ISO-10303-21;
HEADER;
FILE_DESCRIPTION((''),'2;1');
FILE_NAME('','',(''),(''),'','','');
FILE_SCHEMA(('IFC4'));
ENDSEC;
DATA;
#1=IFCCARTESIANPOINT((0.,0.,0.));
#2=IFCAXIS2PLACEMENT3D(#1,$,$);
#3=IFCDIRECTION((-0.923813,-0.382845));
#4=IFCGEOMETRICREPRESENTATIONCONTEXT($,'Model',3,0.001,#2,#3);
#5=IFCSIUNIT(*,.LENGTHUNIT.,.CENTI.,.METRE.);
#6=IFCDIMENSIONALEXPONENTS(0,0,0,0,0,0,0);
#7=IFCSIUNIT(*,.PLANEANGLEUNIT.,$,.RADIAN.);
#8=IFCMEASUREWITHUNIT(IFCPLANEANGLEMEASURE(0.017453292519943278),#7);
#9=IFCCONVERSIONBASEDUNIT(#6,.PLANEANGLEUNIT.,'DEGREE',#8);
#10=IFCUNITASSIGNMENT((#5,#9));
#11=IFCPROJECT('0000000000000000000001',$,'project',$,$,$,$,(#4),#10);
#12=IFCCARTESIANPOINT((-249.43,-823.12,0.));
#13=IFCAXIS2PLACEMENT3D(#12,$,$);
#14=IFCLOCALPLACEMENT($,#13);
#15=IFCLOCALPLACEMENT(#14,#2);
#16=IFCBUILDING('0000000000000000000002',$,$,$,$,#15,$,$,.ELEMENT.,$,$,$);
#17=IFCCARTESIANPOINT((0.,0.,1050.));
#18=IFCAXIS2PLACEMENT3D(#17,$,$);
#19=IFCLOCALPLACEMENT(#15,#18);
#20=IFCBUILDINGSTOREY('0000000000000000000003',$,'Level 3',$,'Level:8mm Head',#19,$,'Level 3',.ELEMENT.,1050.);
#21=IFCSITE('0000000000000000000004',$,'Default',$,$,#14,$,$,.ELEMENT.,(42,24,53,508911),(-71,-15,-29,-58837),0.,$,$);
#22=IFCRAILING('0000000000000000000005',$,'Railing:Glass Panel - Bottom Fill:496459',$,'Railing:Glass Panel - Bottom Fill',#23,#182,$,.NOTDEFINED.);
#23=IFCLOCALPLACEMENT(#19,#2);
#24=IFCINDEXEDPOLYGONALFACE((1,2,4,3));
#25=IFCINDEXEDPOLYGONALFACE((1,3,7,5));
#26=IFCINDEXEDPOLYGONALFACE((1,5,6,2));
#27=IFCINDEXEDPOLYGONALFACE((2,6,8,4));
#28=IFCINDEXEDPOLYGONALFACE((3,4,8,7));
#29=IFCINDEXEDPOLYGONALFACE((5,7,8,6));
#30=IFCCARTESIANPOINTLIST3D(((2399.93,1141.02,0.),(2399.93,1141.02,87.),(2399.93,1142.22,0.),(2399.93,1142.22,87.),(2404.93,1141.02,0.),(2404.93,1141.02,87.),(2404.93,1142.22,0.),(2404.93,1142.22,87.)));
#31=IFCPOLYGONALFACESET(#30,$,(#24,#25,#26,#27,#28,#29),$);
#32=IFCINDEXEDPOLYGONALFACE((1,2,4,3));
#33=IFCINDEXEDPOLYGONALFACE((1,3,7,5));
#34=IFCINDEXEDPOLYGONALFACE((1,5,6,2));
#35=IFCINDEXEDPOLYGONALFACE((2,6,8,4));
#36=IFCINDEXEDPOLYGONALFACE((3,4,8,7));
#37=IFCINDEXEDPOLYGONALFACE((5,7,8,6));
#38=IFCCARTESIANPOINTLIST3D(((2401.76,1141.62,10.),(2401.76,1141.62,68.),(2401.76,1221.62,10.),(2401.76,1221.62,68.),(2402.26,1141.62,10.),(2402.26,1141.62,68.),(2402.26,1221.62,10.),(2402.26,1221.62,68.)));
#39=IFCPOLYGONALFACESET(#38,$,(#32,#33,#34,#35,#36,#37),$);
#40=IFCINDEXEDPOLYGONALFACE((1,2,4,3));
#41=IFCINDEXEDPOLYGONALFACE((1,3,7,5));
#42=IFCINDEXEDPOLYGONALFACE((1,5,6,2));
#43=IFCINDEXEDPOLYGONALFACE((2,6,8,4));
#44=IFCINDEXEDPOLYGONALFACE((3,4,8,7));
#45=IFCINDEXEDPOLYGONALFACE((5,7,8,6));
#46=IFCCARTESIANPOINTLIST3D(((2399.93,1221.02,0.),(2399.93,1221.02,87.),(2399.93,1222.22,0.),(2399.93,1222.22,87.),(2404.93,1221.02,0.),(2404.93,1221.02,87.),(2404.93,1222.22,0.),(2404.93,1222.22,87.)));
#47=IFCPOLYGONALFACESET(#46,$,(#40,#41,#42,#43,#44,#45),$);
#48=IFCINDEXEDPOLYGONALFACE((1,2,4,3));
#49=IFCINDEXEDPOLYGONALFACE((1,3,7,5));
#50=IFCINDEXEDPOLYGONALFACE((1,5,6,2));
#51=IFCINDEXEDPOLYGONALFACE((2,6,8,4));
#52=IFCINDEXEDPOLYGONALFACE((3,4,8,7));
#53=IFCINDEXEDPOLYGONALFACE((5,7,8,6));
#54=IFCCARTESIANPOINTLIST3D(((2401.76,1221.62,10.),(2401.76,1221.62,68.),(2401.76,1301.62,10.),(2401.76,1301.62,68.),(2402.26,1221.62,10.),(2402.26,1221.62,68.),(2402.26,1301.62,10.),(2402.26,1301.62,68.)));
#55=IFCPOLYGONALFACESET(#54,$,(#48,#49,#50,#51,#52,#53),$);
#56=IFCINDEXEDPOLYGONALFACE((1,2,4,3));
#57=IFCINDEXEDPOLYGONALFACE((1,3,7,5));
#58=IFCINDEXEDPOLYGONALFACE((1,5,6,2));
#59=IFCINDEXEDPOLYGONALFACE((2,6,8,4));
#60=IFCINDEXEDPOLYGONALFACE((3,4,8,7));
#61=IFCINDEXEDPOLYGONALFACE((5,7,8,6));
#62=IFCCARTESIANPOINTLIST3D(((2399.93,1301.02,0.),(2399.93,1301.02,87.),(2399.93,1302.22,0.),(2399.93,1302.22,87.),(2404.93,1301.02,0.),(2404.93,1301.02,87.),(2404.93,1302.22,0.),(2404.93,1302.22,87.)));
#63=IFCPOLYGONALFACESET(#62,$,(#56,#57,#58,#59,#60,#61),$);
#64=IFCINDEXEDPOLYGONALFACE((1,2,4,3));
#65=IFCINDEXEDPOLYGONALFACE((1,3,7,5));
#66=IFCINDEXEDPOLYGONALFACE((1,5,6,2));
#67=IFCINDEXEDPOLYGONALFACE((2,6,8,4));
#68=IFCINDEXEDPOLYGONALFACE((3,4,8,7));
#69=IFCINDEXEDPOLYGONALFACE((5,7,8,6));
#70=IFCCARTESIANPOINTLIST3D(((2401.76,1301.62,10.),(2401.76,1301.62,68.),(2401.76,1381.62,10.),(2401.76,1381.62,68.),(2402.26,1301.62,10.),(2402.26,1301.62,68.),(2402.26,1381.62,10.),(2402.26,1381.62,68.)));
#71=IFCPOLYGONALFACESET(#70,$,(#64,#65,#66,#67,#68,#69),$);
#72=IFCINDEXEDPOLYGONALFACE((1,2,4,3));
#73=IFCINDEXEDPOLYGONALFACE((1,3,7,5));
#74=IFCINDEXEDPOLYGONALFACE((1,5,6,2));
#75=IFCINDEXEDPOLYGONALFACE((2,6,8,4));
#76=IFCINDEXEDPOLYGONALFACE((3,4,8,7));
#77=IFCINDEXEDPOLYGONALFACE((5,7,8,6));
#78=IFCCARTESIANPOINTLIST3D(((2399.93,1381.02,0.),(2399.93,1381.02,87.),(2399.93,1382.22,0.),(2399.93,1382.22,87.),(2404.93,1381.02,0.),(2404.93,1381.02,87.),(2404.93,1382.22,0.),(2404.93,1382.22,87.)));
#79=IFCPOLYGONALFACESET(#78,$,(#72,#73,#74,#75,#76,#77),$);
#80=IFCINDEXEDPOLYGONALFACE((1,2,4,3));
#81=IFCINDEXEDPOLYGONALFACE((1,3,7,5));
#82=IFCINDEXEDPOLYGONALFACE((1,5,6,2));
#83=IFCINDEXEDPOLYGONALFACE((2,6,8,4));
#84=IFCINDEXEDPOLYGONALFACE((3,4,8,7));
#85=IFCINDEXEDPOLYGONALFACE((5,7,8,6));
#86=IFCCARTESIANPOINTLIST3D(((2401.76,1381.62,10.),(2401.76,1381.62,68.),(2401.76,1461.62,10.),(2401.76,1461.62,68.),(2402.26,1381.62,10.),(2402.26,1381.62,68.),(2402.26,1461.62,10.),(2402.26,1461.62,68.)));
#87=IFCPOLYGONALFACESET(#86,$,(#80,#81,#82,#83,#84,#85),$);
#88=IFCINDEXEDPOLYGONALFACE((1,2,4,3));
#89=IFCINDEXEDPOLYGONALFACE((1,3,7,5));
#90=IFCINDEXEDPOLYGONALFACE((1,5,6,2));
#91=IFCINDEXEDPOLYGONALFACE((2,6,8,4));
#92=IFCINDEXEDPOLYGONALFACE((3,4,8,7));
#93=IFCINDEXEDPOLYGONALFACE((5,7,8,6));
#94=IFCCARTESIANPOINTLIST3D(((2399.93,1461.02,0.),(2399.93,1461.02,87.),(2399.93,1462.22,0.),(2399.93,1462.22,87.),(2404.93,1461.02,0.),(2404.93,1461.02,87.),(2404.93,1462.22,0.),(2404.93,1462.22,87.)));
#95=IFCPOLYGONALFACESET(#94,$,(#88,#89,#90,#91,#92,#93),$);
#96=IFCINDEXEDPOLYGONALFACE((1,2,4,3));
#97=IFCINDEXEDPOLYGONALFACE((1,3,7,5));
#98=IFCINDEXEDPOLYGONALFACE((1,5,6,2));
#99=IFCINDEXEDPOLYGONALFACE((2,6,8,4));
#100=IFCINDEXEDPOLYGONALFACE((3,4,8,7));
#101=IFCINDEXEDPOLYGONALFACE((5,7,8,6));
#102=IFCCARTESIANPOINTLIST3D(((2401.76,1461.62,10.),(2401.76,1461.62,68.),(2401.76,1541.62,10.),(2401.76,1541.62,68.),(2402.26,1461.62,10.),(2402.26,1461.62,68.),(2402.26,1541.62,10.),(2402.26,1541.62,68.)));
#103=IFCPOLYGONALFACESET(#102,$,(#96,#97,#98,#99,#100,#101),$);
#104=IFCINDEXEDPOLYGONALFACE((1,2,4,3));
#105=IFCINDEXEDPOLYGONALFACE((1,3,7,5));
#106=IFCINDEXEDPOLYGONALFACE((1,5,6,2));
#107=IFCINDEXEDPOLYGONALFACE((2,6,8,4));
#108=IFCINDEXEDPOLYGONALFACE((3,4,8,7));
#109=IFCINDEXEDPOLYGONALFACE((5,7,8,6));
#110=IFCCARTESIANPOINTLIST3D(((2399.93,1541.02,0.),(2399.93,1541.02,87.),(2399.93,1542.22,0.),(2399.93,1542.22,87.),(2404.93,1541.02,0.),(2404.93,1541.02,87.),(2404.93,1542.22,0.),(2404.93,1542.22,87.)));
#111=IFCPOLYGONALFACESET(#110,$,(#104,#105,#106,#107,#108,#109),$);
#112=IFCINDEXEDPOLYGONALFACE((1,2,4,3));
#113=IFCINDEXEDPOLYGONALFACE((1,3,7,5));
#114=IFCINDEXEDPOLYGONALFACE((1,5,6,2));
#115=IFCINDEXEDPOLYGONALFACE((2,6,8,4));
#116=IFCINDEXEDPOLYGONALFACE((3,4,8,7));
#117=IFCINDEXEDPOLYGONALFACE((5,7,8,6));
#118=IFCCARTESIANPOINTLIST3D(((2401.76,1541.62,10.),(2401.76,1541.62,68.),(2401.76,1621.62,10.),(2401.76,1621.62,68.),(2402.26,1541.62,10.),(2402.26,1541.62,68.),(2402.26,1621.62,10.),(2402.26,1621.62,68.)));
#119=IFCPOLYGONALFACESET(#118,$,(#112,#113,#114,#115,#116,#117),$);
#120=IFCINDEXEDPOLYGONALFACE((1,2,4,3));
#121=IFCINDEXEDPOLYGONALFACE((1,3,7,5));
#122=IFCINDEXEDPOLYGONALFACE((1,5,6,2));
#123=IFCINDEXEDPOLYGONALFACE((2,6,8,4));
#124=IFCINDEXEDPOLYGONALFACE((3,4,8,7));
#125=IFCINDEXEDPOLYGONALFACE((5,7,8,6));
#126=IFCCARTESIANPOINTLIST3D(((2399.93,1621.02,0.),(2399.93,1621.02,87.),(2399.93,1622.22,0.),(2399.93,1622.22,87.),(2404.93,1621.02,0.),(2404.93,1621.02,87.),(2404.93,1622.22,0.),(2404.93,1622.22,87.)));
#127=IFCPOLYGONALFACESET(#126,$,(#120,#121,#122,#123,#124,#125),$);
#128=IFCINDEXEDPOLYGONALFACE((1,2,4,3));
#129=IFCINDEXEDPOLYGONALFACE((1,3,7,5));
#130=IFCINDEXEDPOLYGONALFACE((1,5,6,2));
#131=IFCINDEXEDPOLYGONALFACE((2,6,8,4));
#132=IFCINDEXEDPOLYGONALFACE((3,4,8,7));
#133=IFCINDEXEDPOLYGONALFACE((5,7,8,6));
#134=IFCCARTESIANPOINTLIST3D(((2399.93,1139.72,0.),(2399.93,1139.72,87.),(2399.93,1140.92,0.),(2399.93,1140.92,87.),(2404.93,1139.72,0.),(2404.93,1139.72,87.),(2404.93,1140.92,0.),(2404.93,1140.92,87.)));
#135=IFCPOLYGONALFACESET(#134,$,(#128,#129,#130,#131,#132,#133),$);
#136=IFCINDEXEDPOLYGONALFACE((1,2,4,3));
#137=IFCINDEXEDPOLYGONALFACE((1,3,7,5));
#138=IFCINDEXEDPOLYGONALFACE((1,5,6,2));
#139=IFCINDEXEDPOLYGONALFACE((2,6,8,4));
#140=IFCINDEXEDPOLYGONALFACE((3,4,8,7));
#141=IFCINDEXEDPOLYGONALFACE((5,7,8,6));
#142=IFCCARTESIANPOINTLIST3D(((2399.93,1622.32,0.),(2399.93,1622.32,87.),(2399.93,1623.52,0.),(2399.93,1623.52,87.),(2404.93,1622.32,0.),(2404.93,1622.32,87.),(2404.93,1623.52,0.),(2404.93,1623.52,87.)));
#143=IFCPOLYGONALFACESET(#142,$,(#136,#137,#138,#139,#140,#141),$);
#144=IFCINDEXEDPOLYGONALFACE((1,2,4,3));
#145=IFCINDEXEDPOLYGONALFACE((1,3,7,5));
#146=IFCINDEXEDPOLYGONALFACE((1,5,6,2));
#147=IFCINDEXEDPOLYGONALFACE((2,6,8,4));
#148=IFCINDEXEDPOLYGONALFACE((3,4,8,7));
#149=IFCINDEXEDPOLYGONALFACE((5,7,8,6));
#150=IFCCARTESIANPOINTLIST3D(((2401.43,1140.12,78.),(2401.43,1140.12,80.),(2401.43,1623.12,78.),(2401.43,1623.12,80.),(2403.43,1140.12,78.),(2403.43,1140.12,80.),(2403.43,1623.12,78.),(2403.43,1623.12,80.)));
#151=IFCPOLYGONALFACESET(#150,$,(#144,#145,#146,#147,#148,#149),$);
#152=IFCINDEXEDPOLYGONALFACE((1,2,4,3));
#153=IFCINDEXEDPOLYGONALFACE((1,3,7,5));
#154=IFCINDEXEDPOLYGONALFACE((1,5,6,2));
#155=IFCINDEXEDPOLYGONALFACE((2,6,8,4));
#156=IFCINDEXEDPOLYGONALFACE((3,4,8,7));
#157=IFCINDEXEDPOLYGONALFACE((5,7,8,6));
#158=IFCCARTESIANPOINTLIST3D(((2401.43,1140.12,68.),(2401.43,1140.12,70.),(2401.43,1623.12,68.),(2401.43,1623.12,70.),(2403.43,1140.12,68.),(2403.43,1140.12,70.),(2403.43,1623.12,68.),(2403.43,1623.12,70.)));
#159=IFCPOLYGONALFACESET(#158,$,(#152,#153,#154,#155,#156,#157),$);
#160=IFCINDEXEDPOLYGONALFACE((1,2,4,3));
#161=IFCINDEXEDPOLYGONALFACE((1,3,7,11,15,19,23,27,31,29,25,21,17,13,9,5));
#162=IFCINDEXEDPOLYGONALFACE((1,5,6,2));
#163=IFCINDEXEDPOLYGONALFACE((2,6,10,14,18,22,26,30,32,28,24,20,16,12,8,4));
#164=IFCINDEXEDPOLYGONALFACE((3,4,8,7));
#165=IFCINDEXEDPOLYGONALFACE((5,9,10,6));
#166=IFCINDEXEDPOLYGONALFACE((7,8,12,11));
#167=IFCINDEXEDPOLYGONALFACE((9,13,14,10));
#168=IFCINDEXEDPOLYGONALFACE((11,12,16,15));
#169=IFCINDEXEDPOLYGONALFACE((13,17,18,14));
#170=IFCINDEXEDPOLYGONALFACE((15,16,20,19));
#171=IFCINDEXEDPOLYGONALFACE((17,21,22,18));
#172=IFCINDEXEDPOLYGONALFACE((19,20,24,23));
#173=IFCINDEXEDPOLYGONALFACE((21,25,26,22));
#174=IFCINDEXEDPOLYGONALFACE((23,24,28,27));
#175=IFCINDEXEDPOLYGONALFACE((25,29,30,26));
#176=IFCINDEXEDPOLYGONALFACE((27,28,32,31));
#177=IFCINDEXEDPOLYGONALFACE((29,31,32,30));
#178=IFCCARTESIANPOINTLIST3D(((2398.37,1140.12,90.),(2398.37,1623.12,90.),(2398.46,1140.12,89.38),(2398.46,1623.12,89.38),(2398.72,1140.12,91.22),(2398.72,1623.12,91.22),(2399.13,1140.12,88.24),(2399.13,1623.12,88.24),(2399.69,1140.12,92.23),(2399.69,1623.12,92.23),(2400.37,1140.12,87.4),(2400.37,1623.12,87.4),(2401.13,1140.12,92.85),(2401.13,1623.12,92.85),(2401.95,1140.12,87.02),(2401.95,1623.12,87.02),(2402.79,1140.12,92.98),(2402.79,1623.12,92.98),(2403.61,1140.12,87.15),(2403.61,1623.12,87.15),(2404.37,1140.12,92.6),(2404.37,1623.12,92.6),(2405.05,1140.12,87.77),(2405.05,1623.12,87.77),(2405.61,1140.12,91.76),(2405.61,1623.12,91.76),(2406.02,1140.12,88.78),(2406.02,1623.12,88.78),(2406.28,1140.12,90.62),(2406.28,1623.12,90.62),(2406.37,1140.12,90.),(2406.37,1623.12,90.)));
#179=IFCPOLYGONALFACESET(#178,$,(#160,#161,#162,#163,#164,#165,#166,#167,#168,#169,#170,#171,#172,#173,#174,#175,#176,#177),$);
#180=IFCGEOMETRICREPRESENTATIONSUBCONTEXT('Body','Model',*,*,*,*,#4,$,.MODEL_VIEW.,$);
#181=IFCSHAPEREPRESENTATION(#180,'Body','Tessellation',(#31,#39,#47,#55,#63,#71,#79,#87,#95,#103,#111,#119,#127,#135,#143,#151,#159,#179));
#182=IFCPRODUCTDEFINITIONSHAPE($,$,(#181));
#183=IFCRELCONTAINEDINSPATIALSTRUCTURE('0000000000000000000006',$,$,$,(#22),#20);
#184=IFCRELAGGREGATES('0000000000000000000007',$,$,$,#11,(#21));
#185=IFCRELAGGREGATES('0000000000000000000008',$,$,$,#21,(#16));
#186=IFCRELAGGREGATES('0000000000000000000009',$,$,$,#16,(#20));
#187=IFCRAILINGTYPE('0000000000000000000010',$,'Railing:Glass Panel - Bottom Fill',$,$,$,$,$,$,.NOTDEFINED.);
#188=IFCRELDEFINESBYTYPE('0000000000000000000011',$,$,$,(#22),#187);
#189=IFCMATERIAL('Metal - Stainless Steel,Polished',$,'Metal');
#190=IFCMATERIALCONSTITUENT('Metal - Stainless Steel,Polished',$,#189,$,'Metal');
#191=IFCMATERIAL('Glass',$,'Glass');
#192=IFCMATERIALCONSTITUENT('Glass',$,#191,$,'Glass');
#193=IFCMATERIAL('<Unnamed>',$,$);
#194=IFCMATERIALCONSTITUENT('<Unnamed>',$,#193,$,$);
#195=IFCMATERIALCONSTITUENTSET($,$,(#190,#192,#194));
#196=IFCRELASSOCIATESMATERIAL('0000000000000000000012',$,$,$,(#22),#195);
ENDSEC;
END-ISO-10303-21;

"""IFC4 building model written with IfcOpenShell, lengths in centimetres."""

from ifc_helpers import new_model, entity, si_unit, converted_unit, direction, frame, origin, place, context, subcontext, project, spatial, indexed_curve, outline, extrude, material, constituent, constituent_set, type_object, element, save


model = new_model("IFC4")

# Units and contexts
model_context = context("Model", 3, precision=0.001, world=origin(), true_north=direction((-0.923813, -0.382845)))
body_context = subcontext(model_context, "Body", "Model", "MODEL_VIEW")
ifc_project = project(units=[si_unit("LENGTHUNIT", "METRE", prefix="CENTI"), converted_unit("PLANEANGLEUNIT", "DEGREE", entity("IfcPlaneAngleMeasure", 0.017453292519943278), si_unit("PLANEANGLEUNIT", "RADIAN"), dimensions=[0, 0, 0, 0, 0, 0, 0])], contexts=[model_context])

# Site, building, storey
site_placement = place(None, frame((-249.43, -823.12, 0.0)))
site = spatial("IfcSite", under=ifc_project, at=site_placement, Name="Default", CompositionType="ELEMENT", RefLatitude=(42, 24, 53, 508911), RefLongitude=(-71, -15, -29, -58837), RefElevation=0.0)
building_placement = place(site_placement, origin())
building = spatial("IfcBuilding", under=site, at=building_placement, CompositionType="ELEMENT")
storey_placement = place(building_placement, frame((0.0, 0.0, 1050.0)))
storey = spatial("IfcBuildingStorey", under=building, at=storey_placement, Name="Level 3", ObjectType="Level:8mm Head", LongName="Level 3", CompositionType="ELEMENT", Elevation=1050.0)

# Railing
ifc_material_1 = material(Name="Metal - Stainless Steel,Polished", Category="Metal")
ifc_constituent_1 = constituent(ifc_material_1, Name="Metal - Stainless Steel,Polished", Category="Metal")
ifc_material_2 = material(Name="Glass", Category="Glass")
ifc_constituent_2 = constituent(ifc_material_2, Name="Glass", Category="Glass")
ifc_material_3 = material(Name="<Unnamed>")
ifc_constituent_3 = constituent(ifc_material_3, Name="<Unnamed>")
ifc_constituent_set_1 = constituent_set(constituents=[ifc_constituent_1, ifc_constituent_2, ifc_constituent_3])
railing_type = type_object("IfcRailingType", Name="Railing:Glass Panel - Bottom Fill", PredefinedType="NOTDEFINED")
railing_placement = place(storey_placement, frame((2398.21, 1139.72, 0.0)))
element("IfcRailing", 1, at=railing_placement, inside=storey, type_object=railing_type, material=ifc_constituent_set_1, Name="Railing:Glass Panel - Bottom Fill:496459", ObjectType="Railing:Glass Panel - Bottom Fill", PredefinedType="NOTDEFINED", context=body_context, shape_type="SweptSolid", body=[
    extrude(outline(indexed_curve([(-2.5, -0.6), (2.5, -0.6), (2.5, 0.6), (-2.5, 0.6), (-2.5, -0.6)], self_intersect=False)), frame((4.22, 1.9, 0.0), z_axis=(0.0, 0.0, 1.0), x_axis=(-1.0, 0.0, 0.0)), (0.0, 0.0, 1.0), 87.0),
    extrude(outline(indexed_curve([(-0.25, -40.0), (0.25, -40.0), (0.25, 40.0), (-0.25, 40.0), (-0.25, -40.0)], self_intersect=False)), frame((3.8, 41.9, 10.0), z_axis=(0.0, 0.0, 1.0), x_axis=(-1.0, 0.0, 0.0)), (0.0, 0.0, 1.0), 58.0),
    extrude(outline(indexed_curve([(-2.5, -0.6), (2.5, -0.6), (2.5, 0.6), (-2.5, 0.6), (-2.5, -0.6)], self_intersect=False)), frame((4.22, 81.9, 0.0), z_axis=(0.0, 0.0, 1.0), x_axis=(-1.0, 0.0, 0.0)), (0.0, 0.0, 1.0), 87.0),
    extrude(outline(indexed_curve([(-0.25, -40.0), (0.25, -40.0), (0.25, 40.0), (-0.25, 40.0), (-0.25, -40.0)], self_intersect=False)), frame((3.8, 121.9, 10.0), z_axis=(0.0, 0.0, 1.0), x_axis=(-1.0, 0.0, 0.0)), (0.0, 0.0, 1.0), 58.0),
    extrude(outline(indexed_curve([(-2.5, -0.6), (2.5, -0.6), (2.5, 0.6), (-2.5, 0.6), (-2.5, -0.6)], self_intersect=False)), frame((4.22, 161.9, 0.0), z_axis=(0.0, 0.0, 1.0), x_axis=(-1.0, 0.0, 0.0)), (0.0, 0.0, 1.0), 87.0),
    extrude(outline(indexed_curve([(-0.25, -40.0), (0.25, -40.0), (0.25, 40.0), (-0.25, 40.0), (-0.25, -40.0)], self_intersect=False)), frame((3.8, 201.9, 10.0), z_axis=(0.0, 0.0, 1.0), x_axis=(-1.0, 0.0, 0.0)), (0.0, 0.0, 1.0), 58.0),
    extrude(outline(indexed_curve([(-2.5, -0.6), (2.5, -0.6), (2.5, 0.6), (-2.5, 0.6), (-2.5, -0.6)], self_intersect=False)), frame((4.22, 241.9, 0.0), z_axis=(0.0, 0.0, 1.0), x_axis=(-1.0, 0.0, 0.0)), (0.0, 0.0, 1.0), 87.0),
    extrude(outline(indexed_curve([(-0.25, -40.0), (0.25, -40.0), (0.25, 40.0), (-0.25, 40.0), (-0.25, -40.0)], self_intersect=False)), frame((3.8, 281.9, 10.0), z_axis=(0.0, 0.0, 1.0), x_axis=(-1.0, 0.0, 0.0)), (0.0, 0.0, 1.0), 58.0),
    extrude(outline(indexed_curve([(-2.5, -0.6), (2.5, -0.6), (2.5, 0.6), (-2.5, 0.6), (-2.5, -0.6)], self_intersect=False)), frame((4.22, 321.9, 0.0), z_axis=(0.0, 0.0, 1.0), x_axis=(-1.0, 0.0, 0.0)), (0.0, 0.0, 1.0), 87.0),
    extrude(outline(indexed_curve([(-0.25, -40.0), (0.25, -40.0), (0.25, 40.0), (-0.25, 40.0), (-0.25, -40.0)], self_intersect=False)), frame((3.8, 361.9, 10.0), z_axis=(0.0, 0.0, 1.0), x_axis=(-1.0, 0.0, 0.0)), (0.0, 0.0, 1.0), 58.0),
    extrude(outline(indexed_curve([(-2.5, -0.6), (2.5, -0.6), (2.5, 0.6), (-2.5, 0.6), (-2.5, -0.6)], self_intersect=False)), frame((4.22, 401.9, 0.0), z_axis=(0.0, 0.0, 1.0), x_axis=(-1.0, 0.0, 0.0)), (0.0, 0.0, 1.0), 87.0),
    extrude(outline(indexed_curve([(-0.25, -40.0), (0.25, -40.0), (0.25, 40.0), (-0.25, 40.0), (-0.25, -40.0)], self_intersect=False)), frame((3.8, 441.9, 10.0), z_axis=(0.0, 0.0, 1.0), x_axis=(-1.0, 0.0, 0.0)), (0.0, 0.0, 1.0), 58.0),
    extrude(outline(indexed_curve([(-2.5, -0.6), (2.5, -0.6), (2.5, 0.6), (-2.5, 0.6), (-2.5, -0.6)], self_intersect=False)), frame((4.22, 481.9, 0.0), z_axis=(0.0, 0.0, 1.0), x_axis=(-1.0, 0.0, 0.0)), (0.0, 0.0, 1.0), 87.0),
    extrude(outline(indexed_curve([(-2.5, -0.6), (2.5, -0.6), (2.5, 0.6), (-2.5, 0.6), (-2.5, -0.6)], self_intersect=False)), frame((4.22, 0.6, 0.0), z_axis=(0.0, 0.0, 1.0), x_axis=(-1.0, 0.0, 0.0)), (0.0, 0.0, 1.0), 87.0),
    extrude(outline(indexed_curve([(-2.5, -0.6), (2.5, -0.6), (2.5, 0.6), (-2.5, 0.6), (-2.5, -0.6)], self_intersect=False)), frame((4.22, 483.2, 0.0), z_axis=(0.0, 0.0, 1.0), x_axis=(-1.0, 0.0, 0.0)), (0.0, 0.0, 1.0), 87.0),
    extrude(outline(indexed_curve([(-241.5, -1.0), (241.5, -1.0), (241.5, 1.0), (-241.5, 1.0), (-241.5, -1.0)], self_intersect=False)), frame((4.22, 241.9, 78.0), z_axis=(0.0, 0.0, 1.0), x_axis=(0.0, -1.0, 0.0)), (0.0, 0.0, 1.0), 2.0),
    extrude(outline(indexed_curve([(-241.5, -1.0), (241.5, -1.0), (241.5, 1.0), (-241.5, 1.0), (-241.5, -1.0)], self_intersect=False)), frame((4.22, 241.9, 68.0), z_axis=(0.0, 0.0, 1.0), x_axis=(0.0, -1.0, 0.0)), (0.0, 0.0, 1.0), 2.0),
    extrude(outline(indexed_curve([(-1.09, -3.85), (0.18, -3.85), (1.42, -3.18), (2.41, -1.97), (2.98, -0.41), (3.04, 1.22), (2.58, 2.63), (1.67, 3.59), (1.09, 3.85), (-0.18, 3.85), (-1.42, 3.18), (-2.41, 1.97), (-2.98, 0.41), (-3.04, -1.22), (-2.58, -2.63), (-1.67, -3.59), (-1.09, -3.85)], self_intersect=False)), frame((4.16, 0.4, 90.0), z_axis=(0.0, 1.0, 0.0), x_axis=(-0.27267, 0.0, -0.962108)), (0.0, 0.0, 1.0), 483.0),
])

save(model, "model.ifc")
